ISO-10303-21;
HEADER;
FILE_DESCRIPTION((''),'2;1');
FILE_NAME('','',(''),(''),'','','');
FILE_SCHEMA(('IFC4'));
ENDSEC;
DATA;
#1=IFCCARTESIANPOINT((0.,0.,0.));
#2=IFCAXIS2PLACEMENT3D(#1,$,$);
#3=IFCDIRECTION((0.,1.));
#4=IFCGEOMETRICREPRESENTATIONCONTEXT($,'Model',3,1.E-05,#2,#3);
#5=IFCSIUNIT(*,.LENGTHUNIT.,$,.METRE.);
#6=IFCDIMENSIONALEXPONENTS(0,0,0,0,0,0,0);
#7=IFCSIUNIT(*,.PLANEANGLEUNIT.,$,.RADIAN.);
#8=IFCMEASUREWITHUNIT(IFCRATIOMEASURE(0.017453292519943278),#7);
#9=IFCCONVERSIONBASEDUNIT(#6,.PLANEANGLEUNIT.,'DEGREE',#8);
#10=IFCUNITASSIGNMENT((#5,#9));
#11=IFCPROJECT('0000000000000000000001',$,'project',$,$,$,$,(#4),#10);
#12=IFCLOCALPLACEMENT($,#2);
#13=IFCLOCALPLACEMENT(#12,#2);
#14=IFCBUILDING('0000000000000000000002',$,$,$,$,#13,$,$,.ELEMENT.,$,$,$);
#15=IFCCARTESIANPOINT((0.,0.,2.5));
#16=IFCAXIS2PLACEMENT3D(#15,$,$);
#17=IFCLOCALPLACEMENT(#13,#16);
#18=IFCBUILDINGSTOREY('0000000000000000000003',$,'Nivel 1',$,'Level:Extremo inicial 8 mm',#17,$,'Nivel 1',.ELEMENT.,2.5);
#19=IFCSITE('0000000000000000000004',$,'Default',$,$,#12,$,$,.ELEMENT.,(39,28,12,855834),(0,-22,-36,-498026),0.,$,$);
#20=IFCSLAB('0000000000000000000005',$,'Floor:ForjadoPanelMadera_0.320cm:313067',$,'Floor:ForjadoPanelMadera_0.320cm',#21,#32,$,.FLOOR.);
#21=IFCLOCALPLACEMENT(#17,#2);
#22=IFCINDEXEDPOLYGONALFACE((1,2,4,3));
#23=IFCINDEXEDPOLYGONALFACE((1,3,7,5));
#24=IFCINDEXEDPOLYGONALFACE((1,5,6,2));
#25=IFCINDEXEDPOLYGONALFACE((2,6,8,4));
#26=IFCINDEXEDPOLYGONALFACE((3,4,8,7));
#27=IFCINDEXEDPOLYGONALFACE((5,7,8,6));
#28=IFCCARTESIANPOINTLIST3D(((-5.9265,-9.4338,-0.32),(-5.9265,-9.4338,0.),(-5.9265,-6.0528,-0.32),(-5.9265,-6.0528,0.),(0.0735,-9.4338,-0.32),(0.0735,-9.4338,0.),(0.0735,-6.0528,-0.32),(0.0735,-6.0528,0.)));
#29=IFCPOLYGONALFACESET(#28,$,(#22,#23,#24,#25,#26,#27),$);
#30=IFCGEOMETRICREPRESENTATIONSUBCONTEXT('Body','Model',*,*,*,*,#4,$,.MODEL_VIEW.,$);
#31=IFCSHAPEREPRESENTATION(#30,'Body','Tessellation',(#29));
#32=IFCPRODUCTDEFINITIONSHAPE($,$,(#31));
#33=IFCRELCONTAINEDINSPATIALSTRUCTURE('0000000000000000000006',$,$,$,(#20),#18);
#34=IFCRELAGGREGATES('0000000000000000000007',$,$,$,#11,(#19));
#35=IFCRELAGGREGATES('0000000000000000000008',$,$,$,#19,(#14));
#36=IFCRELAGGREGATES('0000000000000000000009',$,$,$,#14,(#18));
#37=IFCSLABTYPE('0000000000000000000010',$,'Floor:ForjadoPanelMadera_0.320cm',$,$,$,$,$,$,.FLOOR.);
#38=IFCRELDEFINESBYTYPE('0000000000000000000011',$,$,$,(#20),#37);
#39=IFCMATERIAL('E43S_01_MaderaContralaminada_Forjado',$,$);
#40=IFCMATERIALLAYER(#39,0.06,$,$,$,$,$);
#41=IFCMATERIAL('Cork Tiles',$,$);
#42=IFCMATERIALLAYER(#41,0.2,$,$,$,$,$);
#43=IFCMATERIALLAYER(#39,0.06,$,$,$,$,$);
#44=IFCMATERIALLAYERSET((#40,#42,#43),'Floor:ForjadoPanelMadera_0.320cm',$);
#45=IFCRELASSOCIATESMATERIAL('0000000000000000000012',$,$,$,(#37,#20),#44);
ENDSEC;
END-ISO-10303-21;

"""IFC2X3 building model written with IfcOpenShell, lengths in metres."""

from ifc_helpers import new_model, entity, si_unit, converted_unit, direction, frame, frame_2d, origin, place, context, subcontext, project, spatial, rectangle, extrude, material, layer, layer_set, layer_usage, type_object, element, save


model = new_model("IFC2X3")

# Units and contexts
model_context = context("Model", 3, precision=1e-05, world=origin(), true_north=direction((0.0, 1.0)))
body_context = subcontext(model_context, "Body", "Model", "MODEL_VIEW")
ifc_project = project(units=[si_unit("LENGTHUNIT", "METRE"), converted_unit("PLANEANGLEUNIT", "DEGREE", entity("IfcRatioMeasure", 0.017453292519943278), si_unit("PLANEANGLEUNIT", "RADIAN"), dimensions=[0, 0, 0, 0, 0, 0, 0])], contexts=[model_context])

# Site, building, storey
site_placement = place(None, origin())
site = spatial("IfcSite", under=ifc_project, at=site_placement, Name="Default", CompositionType="ELEMENT", RefLatitude=(39, 28, 12, 855834), RefLongitude=(0, -22, -36, -498026), RefElevation=0.0)
building_placement = place(site_placement, origin())
building = spatial("IfcBuilding", under=site, at=building_placement, CompositionType="ELEMENT")
storey_placement = place(building_placement, frame((0.0, 0.0, 2.5)))
storey = spatial("IfcBuildingStorey", under=building, at=storey_placement, Name="Nivel 1", ObjectType="Level:Extremo inicial 8 mm", LongName="Nivel 1", CompositionType="ELEMENT", Elevation=2.5)

# Slab
ifc_material_1 = material(Name="E43S_01_MaderaContralaminada_Forjado")
ifc_layer_1 = layer(ifc_material_1, 0.06)
ifc_material_2 = material(Name="Cork Tiles")
ifc_layer_2 = layer(ifc_material_2, 0.2)
ifc_layer_3 = layer(ifc_material_1, 0.06)
ifc_layer_set = layer_set([ifc_layer_1, ifc_layer_2, ifc_layer_3], Name="Floor:ForjadoPanelMadera_0.320cm")
ifc_layer_usage = layer_usage(ifc_layer_set, "AXIS3", "POSITIVE", 0.0)
slab_type = type_object("IfcSlabType", Name="Floor:ForjadoPanelMadera_0.320cm", PredefinedType="FLOOR", material=ifc_layer_set)
slab_placement = place(storey_placement, origin())
element("IfcSlab", 1, at=slab_placement, inside=storey, type_object=slab_type, material=ifc_layer_usage, Name="Floor:ForjadoPanelMadera_0.320cm:313067", ObjectType="Floor:ForjadoPanelMadera_0.320cm", PredefinedType="FLOOR", context=body_context, shape_type="SweptSolid", body=[
    extrude(rectangle(XDim=3.381, YDim=6.0, at=frame_2d((0.0, 0.0), x_axis=(1.0, 0.0))), frame((-2.9265, -7.7433, 0.0), z_axis=(0.0, 0.0, -1.0), x_axis=(0.0, 1.0, 0.0)), (0.0, 0.0, 1.0), 0.32),
])

save(model, "model.ifc")
